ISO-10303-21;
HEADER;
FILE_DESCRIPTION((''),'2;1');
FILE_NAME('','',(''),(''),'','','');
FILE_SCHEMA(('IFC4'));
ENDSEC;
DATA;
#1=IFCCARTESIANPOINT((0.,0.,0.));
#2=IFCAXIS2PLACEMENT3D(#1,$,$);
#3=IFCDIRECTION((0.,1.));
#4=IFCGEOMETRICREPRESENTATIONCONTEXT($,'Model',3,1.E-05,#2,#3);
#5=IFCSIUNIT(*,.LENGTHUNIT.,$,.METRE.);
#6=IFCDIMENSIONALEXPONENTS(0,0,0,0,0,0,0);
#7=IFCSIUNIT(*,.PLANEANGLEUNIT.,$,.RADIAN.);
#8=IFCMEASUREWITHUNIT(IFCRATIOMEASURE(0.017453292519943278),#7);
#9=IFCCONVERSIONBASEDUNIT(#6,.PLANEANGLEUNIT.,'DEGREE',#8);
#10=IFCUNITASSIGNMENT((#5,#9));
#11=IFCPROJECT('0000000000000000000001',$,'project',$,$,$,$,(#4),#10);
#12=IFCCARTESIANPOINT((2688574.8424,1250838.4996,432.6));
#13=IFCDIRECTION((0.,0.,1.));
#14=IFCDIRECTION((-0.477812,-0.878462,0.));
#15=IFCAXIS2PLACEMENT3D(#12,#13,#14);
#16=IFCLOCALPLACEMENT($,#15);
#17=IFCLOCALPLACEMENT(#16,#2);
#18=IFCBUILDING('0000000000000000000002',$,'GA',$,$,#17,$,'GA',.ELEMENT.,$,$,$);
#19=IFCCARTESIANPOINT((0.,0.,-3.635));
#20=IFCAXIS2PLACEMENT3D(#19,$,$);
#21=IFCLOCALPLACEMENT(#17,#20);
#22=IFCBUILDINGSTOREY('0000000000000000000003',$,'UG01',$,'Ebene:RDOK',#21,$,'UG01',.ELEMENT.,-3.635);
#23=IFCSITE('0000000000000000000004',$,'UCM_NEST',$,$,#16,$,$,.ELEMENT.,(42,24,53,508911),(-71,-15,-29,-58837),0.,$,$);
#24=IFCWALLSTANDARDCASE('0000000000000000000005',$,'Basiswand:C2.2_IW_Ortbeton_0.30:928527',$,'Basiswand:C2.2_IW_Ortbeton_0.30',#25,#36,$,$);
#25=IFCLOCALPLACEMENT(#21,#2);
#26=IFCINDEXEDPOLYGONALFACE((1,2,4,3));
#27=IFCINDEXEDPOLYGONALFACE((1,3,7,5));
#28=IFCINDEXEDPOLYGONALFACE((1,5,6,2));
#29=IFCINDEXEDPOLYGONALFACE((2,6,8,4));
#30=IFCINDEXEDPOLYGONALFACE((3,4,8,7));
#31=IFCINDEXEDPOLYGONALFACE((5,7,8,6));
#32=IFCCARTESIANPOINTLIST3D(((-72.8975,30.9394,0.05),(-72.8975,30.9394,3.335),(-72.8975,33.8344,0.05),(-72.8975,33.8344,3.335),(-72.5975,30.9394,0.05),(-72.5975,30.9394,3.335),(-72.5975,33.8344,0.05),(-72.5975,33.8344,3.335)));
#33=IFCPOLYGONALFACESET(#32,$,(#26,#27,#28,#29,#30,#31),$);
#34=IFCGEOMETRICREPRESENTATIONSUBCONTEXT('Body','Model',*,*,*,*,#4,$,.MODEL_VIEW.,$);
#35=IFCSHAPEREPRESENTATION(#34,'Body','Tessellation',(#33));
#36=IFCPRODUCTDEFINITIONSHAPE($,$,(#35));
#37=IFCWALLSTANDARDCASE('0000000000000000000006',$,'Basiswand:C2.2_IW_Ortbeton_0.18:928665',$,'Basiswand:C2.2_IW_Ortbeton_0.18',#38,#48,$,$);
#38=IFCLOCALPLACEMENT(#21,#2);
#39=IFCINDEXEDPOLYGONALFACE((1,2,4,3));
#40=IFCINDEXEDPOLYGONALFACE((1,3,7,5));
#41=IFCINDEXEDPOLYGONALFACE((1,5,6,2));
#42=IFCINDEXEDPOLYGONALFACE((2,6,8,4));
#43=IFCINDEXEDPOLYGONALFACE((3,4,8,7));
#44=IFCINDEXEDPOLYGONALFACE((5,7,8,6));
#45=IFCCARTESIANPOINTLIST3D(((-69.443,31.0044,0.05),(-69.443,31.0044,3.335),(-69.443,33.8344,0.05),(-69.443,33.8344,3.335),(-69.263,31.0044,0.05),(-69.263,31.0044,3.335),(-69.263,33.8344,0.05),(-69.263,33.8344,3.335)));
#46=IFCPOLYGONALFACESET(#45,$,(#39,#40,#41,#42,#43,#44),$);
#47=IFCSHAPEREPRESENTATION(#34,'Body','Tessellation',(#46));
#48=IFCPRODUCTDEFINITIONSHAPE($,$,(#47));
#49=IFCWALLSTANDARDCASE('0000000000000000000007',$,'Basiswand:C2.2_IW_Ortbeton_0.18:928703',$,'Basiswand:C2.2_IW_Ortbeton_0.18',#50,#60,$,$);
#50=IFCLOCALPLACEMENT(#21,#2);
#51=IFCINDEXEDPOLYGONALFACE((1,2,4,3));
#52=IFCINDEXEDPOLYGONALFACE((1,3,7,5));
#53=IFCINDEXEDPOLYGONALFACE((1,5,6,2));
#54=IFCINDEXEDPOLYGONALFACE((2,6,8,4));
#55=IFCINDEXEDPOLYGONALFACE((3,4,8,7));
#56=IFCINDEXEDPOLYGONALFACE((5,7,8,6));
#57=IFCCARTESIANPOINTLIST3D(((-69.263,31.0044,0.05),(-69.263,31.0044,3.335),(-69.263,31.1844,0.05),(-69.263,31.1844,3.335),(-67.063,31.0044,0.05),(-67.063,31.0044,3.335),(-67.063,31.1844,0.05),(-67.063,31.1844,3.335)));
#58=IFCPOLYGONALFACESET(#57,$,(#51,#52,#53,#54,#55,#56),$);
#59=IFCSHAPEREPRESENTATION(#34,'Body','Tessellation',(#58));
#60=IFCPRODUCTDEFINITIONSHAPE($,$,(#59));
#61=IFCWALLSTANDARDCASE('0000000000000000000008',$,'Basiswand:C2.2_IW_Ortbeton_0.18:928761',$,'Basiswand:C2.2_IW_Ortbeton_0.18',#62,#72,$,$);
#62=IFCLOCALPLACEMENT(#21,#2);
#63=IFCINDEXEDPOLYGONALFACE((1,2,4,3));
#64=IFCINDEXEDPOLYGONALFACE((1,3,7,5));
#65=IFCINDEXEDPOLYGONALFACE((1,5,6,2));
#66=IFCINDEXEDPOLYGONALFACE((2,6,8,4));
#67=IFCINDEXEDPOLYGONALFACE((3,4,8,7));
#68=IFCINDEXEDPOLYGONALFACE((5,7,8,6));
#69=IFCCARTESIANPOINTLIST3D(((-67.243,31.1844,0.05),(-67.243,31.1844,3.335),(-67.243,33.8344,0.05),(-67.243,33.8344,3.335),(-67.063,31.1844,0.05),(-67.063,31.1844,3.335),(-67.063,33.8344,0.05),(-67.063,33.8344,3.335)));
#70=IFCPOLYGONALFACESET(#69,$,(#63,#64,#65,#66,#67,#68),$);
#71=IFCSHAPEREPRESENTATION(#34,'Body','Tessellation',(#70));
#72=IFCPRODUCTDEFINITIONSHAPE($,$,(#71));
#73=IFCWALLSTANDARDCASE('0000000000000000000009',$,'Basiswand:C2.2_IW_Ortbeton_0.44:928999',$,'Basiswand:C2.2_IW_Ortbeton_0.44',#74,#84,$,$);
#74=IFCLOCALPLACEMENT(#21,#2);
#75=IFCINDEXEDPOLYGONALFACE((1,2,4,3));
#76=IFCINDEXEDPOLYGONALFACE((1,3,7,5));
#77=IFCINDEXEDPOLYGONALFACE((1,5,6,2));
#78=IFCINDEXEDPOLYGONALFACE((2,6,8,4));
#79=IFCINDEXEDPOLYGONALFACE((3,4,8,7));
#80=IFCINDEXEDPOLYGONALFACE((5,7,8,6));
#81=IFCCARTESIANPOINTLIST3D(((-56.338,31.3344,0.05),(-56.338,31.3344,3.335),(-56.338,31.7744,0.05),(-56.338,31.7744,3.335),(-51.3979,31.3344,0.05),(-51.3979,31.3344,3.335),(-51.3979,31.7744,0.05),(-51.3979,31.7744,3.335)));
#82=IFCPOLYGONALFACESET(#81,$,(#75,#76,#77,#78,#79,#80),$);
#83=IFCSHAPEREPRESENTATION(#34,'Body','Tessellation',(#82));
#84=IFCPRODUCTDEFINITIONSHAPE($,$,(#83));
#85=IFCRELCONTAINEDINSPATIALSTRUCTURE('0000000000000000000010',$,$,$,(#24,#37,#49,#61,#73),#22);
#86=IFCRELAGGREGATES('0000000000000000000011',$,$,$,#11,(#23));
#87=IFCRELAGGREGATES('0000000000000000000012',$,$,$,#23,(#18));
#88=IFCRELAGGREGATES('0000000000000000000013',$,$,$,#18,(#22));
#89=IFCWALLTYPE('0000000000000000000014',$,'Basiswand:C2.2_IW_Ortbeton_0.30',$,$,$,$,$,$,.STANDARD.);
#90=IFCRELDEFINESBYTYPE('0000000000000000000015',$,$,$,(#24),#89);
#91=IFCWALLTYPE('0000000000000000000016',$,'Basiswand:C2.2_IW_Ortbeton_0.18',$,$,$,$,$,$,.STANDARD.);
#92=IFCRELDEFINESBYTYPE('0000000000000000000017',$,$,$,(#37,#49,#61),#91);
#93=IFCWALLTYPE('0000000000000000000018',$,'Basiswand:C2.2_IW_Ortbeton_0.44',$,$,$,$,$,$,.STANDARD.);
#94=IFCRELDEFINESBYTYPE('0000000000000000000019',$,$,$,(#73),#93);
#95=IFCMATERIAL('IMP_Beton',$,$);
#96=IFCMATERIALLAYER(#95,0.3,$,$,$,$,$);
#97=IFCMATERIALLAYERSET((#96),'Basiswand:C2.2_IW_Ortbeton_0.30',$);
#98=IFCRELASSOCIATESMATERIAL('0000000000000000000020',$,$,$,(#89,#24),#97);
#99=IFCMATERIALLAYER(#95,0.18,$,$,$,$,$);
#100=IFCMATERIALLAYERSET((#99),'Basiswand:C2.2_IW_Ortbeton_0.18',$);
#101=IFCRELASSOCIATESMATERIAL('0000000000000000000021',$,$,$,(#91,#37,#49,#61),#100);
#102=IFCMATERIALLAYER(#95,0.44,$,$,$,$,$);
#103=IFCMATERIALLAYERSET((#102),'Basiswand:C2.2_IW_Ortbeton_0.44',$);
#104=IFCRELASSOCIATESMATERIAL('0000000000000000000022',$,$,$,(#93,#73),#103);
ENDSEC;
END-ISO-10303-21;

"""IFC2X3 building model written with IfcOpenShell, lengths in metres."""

from ifc_helpers import new_model, entity, si_unit, converted_unit, direction, frame, frame_2d, origin, place, context, subcontext, project, spatial, polyline, rectangle, extrude, clip, bounded_halfspace, material, layer, layer_set, layer_usage, type_object, element, save


model = new_model("IFC2X3")

# Units and contexts
model_context = context("Model", 3, precision=1e-05, world=origin(), true_north=direction((0.0, 1.0)))
body_context = subcontext(model_context, "Body", "Model", "MODEL_VIEW")
ifc_project = project(units=[si_unit("LENGTHUNIT", "METRE"), converted_unit("PLANEANGLEUNIT", "DEGREE", entity("IfcRatioMeasure", 0.017453292519943278), si_unit("PLANEANGLEUNIT", "RADIAN"), dimensions=[0, 0, 0, 0, 0, 0, 0])], contexts=[model_context])

# Site, building, storey
site_placement = place(None, frame((2688574.8424, 1250838.4996, 432.6), z_axis=(0.0, 0.0, 1.0), x_axis=(-0.477812, -0.878462, 0.0)))
site = spatial("IfcSite", under=ifc_project, at=site_placement, Name="UCM_NEST", CompositionType="ELEMENT", RefLatitude=(42, 24, 53, 508911), RefLongitude=(-71, -15, -29, -58837), RefElevation=0.0)
building_placement = place(site_placement, origin())
building = spatial("IfcBuilding", under=site, at=building_placement, Name="GA", LongName="GA", CompositionType="ELEMENT")
storey_placement = place(building_placement, frame((0.0, 0.0, -3.635)))
storey = spatial("IfcBuildingStorey", under=building, at=storey_placement, Name="UG01", ObjectType="Ebene:RDOK", LongName="UG01", CompositionType="ELEMENT", Elevation=-3.635)

# Walls
ifc_material_1 = material(Name="IMP_Beton")
ifc_layer_1 = layer(ifc_material_1, 0.3)
ifc_layer_set_1 = layer_set([ifc_layer_1], Name="Basiswand:C2.2_IW_Ortbeton_0.30")
ifc_layer_usage_1 = layer_usage(ifc_layer_set_1, "AXIS2", "NEGATIVE", 0.15)
wall_type_1 = type_object("IfcWallType", Name="Basiswand:C2.2_IW_Ortbeton_0.30", PredefinedType="STANDARD", material=ifc_layer_set_1)
wall_1_placement = place(storey_placement, frame((-72.7475, 33.8344, 0.05), z_axis=(0.0, 0.0, 1.0), x_axis=(0.0, -1.0, 0.0)))
element("IfcWallStandardCase", 1, at=wall_1_placement, inside=storey, type_object=wall_type_1, material=ifc_layer_usage_1, Name="Basiswand:C2.2_IW_Ortbeton_0.30:928527", ObjectType="Basiswand:C2.2_IW_Ortbeton_0.30", context=body_context, shape_type="Clipping", body=[
    clip(extrude(rectangle(XDim=2.895, YDim=0.3, at=frame_2d((1.4475, 0.0), x_axis=(-1.0, 0.0))), origin(), (0.0, 0.0, 1.0), 3.285), bounded_halfspace(frame((2.895, -0.15, 0.0), z_axis=(0.0, 0.0, 1.0), x_axis=(-1.0, 0.0, 0.0)), True, frame((2.895, -0.15, 0.0), z_axis=(0.0, 0.0, 1.0), x_axis=(-1.0, 0.0, 0.0)), polyline([(0.0, 0.0), (0.0, -0.3), (2.895, -0.3), (2.895, 0.0), (0.0, 0.0)]))),
])
ifc_layer_2 = layer(ifc_material_1, 0.18)
ifc_layer_set_2 = layer_set([ifc_layer_2], Name="Basiswand:C2.2_IW_Ortbeton_0.18")
ifc_layer_usage_2 = layer_usage(ifc_layer_set_2, "AXIS2", "NEGATIVE", 0.09)
wall_type_2 = type_object("IfcWallType", Name="Basiswand:C2.2_IW_Ortbeton_0.18", PredefinedType="STANDARD", material=ifc_layer_set_2)
wall_2_placement = place(storey_placement, frame((-69.353, 33.8344, 0.05), z_axis=(0.0, 0.0, 1.0), x_axis=(0.0, -1.0, 0.0)))
element("IfcWallStandardCase", 2, at=wall_2_placement, inside=storey, type_object=wall_type_2, material=ifc_layer_usage_2, Name="Basiswand:C2.2_IW_Ortbeton_0.18:928665", ObjectType="Basiswand:C2.2_IW_Ortbeton_0.18", context=body_context, shape_type="Clipping", body=[
    clip(extrude(rectangle(XDim=2.83, YDim=0.18, at=frame_2d((1.415, 0.0), x_axis=(-1.0, 0.0))), origin(), (0.0, 0.0, 1.0), 3.285), bounded_halfspace(frame((2.83, -0.09, 0.0), z_axis=(0.0, 0.0, 1.0), x_axis=(-1.0, 0.0, 0.0)), True, frame((2.83, -0.09, 0.0), z_axis=(0.0, 0.0, 1.0), x_axis=(-1.0, 0.0, 0.0)), polyline([(0.0, 0.0), (0.0, -0.18), (0.18, -0.18), (2.83, -0.18), (2.83, 0.0), (0.0, 0.0)]))),
])
wall_3_placement = place(storey_placement, frame((-69.263, 31.0944, 0.05)))
element("IfcWallStandardCase", 3, at=wall_3_placement, inside=storey, type_object=wall_type_2, material=ifc_layer_usage_2, Name="Basiswand:C2.2_IW_Ortbeton_0.18:928703", ObjectType="Basiswand:C2.2_IW_Ortbeton_0.18", context=body_context, shape_type="Clipping", body=[
    clip(extrude(rectangle(XDim=2.2, YDim=0.18, at=frame_2d((1.1, 0.0), x_axis=(-1.0, 0.0))), origin(), (0.0, 0.0, 1.0), 3.285), bounded_halfspace(frame((2.2, -0.09, 0.0), z_axis=(0.0, 0.0, 1.0), x_axis=(0.0, 1.0, 0.0)), True, frame((2.2, -0.09, 0.0), z_axis=(0.0, 0.0, 1.0), x_axis=(0.0, 1.0, 0.0)), polyline([(0.0, 0.0), (0.18, 0.0), (0.18, 0.18), (0.18, 2.2), (0.0, 2.2), (0.0, 0.0)]))),
])
wall_4_placement = place(storey_placement, frame((-67.153, 31.1844, 0.05), z_axis=(0.0, 0.0, 1.0), x_axis=(0.0, 1.0, 0.0)))
element("IfcWallStandardCase", 4, at=wall_4_placement, inside=storey, type_object=wall_type_2, material=ifc_layer_usage_2, Name="Basiswand:C2.2_IW_Ortbeton_0.18:928761", ObjectType="Basiswand:C2.2_IW_Ortbeton_0.18", context=body_context, shape_type="Clipping", body=[
    clip(extrude(rectangle(XDim=2.65, YDim=0.18, at=frame_2d((1.325, 0.0), x_axis=(-1.0, 0.0))), origin(), (0.0, 0.0, 1.0), 3.285), bounded_halfspace(frame((2.65, -0.09, 0.0)), True, frame((2.65, -0.09, 0.0)), polyline([(0.0, 0.0), (0.0, 0.18), (-2.65, 0.18), (-2.65, 0.0), (0.0, 0.0)]))),
])
ifc_layer_3 = layer(ifc_material_1, 0.44)
ifc_layer_set_3 = layer_set([ifc_layer_3], Name="Basiswand:C2.2_IW_Ortbeton_0.44")
ifc_layer_usage_3 = layer_usage(ifc_layer_set_3, "AXIS2", "NEGATIVE", 0.22)
wall_type_3 = type_object("IfcWallType", Name="Basiswand:C2.2_IW_Ortbeton_0.44", PredefinedType="STANDARD", material=ifc_layer_set_3)
wall_5_placement = place(storey_placement, frame((-56.338, 31.5544, 0.05)))
element("IfcWallStandardCase", 5, at=wall_5_placement, inside=storey, type_object=wall_type_3, material=ifc_layer_usage_3, Name="Basiswand:C2.2_IW_Ortbeton_0.44:928999", ObjectType="Basiswand:C2.2_IW_Ortbeton_0.44", context=body_context, shape_type="Clipping", body=[
    clip(extrude(rectangle(XDim=4.94, YDim=0.44, at=frame_2d((2.47, 0.0), x_axis=(-1.0, 0.0))), origin(), (0.0, 0.0, 1.0), 3.285), bounded_halfspace(frame((4.94, -0.22, 0.0), z_axis=(0.0, 0.0, 1.0), x_axis=(0.0, 1.0, 0.0)), True, frame((4.94, -0.22, 0.0), z_axis=(0.0, 0.0, 1.0), x_axis=(0.0, 1.0, 0.0)), polyline([(0.0, 0.0), (0.44, 0.0), (0.44, 4.94), (0.25, 4.94), (0.0, 4.94), (0.0, 0.0)]))),
])

save(model, "model.ifc")
